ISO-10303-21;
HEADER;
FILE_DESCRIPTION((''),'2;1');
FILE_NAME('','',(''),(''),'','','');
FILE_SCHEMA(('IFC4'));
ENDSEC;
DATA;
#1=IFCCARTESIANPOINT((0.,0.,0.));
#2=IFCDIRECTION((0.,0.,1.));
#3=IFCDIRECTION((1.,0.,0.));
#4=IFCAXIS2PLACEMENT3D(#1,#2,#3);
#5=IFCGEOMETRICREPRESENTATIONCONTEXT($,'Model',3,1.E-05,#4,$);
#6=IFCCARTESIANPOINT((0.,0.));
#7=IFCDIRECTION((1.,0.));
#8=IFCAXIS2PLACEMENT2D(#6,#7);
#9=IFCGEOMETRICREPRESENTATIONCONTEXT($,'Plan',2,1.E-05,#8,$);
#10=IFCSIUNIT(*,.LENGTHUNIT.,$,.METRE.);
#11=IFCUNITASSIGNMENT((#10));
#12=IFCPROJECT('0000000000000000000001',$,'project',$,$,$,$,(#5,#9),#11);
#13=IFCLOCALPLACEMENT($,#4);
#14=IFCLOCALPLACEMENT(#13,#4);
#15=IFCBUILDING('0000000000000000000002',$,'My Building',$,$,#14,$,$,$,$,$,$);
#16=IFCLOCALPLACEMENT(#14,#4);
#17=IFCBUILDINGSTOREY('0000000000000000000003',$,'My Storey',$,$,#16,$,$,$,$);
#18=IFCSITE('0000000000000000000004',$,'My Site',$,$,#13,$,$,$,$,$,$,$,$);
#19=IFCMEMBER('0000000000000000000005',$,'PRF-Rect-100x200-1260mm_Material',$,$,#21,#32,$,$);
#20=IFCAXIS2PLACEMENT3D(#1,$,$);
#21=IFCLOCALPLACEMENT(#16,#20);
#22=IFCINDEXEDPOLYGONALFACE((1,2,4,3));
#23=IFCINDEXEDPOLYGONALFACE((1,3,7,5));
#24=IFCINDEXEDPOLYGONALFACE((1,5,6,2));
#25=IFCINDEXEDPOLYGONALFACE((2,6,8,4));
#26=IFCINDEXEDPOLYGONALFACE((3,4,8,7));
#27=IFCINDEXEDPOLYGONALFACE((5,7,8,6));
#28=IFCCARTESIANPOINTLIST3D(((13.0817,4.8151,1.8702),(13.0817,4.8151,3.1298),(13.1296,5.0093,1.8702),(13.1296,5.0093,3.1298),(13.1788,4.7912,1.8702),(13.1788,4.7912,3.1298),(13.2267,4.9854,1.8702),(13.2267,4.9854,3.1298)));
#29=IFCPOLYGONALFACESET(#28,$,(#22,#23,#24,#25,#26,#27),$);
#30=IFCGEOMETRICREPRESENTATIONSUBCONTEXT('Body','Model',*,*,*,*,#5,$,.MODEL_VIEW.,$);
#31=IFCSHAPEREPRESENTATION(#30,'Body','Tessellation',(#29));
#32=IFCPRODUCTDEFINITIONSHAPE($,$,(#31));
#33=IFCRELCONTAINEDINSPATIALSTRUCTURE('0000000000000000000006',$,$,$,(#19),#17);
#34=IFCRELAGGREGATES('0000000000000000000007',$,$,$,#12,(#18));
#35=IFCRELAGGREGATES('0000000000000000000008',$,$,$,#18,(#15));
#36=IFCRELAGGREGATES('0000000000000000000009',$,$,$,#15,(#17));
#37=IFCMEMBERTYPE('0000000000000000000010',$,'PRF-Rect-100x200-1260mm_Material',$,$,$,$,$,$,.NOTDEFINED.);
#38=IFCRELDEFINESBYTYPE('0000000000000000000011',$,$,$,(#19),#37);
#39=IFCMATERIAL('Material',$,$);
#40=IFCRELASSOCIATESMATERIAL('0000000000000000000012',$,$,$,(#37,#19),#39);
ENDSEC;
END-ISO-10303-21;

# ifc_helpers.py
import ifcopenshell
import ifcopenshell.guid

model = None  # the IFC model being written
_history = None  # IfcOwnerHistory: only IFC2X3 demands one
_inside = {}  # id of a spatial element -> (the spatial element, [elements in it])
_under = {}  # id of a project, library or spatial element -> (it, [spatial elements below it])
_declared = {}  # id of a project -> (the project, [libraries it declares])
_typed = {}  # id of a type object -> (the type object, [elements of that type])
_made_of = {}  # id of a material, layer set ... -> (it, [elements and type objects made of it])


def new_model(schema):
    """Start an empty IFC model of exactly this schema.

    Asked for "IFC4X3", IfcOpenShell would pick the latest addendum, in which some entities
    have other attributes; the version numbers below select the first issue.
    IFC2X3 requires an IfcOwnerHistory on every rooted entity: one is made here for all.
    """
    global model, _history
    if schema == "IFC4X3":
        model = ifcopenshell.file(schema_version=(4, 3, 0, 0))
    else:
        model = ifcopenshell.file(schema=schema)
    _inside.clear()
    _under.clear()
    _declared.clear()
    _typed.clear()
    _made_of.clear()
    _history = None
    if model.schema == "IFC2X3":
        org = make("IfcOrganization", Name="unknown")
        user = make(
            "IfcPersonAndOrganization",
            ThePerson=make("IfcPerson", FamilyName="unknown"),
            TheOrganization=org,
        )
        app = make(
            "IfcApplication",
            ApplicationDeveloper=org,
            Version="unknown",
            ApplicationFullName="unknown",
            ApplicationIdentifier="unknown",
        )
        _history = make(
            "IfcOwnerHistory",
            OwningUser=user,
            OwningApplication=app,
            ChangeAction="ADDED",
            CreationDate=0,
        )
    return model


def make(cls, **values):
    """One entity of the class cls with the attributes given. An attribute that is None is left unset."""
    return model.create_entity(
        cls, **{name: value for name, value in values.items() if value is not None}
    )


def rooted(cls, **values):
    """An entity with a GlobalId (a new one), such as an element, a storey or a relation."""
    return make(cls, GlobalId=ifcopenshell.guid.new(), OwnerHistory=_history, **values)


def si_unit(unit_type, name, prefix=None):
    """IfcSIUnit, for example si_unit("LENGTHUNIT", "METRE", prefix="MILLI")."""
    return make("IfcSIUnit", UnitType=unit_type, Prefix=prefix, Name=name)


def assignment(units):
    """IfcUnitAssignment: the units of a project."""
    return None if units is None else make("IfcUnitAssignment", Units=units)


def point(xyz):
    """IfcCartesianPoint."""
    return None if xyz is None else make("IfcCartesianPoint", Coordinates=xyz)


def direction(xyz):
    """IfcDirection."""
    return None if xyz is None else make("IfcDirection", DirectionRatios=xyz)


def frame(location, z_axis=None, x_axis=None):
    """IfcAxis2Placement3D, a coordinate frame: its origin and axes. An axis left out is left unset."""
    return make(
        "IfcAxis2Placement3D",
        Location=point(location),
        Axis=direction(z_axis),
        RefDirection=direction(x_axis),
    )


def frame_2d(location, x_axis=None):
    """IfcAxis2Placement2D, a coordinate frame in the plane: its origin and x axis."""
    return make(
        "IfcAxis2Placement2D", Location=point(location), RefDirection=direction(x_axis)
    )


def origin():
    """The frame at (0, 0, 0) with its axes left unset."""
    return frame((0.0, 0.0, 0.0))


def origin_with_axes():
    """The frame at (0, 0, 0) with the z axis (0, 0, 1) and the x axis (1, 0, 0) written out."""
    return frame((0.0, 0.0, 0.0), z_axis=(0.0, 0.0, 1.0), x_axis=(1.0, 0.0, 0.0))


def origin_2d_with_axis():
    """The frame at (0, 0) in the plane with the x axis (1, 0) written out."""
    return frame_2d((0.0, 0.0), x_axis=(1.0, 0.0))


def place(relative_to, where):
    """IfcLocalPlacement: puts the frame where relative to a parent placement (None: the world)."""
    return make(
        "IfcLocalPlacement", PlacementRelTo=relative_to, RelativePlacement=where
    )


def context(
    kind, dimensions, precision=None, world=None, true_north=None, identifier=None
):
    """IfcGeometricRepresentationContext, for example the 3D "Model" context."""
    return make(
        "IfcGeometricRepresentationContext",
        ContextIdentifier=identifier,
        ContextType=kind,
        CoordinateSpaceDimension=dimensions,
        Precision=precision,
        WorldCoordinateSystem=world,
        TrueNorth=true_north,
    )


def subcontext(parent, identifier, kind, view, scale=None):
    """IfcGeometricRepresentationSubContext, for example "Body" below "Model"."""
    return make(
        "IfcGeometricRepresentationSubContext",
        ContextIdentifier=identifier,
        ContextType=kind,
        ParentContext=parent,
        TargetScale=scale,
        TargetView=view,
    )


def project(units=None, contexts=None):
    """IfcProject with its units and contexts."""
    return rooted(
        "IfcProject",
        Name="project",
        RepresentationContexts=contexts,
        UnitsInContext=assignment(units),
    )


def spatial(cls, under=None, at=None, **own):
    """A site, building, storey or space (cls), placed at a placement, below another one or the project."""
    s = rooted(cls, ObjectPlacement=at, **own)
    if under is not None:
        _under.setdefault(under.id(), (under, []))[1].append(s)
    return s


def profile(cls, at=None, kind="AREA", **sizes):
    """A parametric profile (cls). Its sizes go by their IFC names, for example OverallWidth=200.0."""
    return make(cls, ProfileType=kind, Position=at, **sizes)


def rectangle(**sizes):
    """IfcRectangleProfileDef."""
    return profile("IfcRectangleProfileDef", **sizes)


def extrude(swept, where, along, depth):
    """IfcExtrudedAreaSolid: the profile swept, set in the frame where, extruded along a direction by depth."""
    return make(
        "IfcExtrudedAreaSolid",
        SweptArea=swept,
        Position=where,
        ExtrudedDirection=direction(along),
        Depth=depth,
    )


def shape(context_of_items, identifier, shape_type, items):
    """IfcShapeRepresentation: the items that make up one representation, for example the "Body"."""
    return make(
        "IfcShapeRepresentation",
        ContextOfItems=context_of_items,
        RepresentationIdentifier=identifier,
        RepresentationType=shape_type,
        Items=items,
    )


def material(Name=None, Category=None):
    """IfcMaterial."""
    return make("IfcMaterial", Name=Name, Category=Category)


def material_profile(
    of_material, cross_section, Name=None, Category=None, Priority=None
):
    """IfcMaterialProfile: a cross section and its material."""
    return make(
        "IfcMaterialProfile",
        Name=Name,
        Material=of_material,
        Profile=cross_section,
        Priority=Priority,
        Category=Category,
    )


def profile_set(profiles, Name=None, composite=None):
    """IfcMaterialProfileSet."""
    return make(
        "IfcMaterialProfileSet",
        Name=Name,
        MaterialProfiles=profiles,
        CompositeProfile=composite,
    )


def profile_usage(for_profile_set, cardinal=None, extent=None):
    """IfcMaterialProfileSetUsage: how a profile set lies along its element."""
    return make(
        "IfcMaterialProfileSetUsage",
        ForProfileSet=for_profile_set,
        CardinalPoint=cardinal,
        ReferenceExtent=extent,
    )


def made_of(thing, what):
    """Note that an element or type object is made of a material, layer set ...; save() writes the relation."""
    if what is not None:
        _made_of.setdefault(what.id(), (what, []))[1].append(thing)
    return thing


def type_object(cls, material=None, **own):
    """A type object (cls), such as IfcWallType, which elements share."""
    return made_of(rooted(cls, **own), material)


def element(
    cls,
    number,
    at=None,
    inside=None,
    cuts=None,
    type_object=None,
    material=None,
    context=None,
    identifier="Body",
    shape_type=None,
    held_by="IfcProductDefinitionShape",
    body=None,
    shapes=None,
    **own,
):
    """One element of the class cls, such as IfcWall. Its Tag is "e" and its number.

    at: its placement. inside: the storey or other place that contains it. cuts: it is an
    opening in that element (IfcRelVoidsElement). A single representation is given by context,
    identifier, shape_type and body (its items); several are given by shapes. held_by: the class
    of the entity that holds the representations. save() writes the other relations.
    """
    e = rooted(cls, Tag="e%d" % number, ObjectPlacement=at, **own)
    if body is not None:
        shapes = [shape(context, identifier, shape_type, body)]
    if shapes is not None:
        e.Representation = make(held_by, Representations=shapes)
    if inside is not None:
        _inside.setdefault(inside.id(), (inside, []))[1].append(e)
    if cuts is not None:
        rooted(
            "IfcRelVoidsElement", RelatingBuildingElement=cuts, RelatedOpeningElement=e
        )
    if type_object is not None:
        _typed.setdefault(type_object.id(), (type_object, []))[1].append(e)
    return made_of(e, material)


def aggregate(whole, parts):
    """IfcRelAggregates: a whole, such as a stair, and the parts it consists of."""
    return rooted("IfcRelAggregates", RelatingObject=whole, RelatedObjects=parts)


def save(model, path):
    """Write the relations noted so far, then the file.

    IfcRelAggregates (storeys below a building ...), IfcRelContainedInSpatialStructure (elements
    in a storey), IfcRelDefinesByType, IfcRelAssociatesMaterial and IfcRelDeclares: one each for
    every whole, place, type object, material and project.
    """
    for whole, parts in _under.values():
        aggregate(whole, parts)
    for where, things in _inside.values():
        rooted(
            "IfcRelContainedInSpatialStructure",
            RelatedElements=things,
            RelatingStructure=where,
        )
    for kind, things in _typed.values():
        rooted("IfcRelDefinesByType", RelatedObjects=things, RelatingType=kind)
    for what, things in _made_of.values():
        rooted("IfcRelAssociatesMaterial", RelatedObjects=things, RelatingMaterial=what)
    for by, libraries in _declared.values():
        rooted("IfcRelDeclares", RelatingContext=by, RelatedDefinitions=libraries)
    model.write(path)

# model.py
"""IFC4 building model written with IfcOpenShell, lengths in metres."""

from ifc_helpers import new_model, si_unit, frame, origin, origin_with_axes, origin_2d_with_axis, place, context, subcontext, project, spatial, rectangle, extrude, material, material_profile, profile_set, profile_usage, type_object, element, save


model = new_model("IFC4")

# Units and contexts
model_context = context("Model", 3, precision=1e-05, world=origin_with_axes())
plan_context = context("Plan", 2, precision=1e-05, world=origin_2d_with_axis())
body_context = subcontext(model_context, "Body", "Model", "MODEL_VIEW")
ifc_project = project(units=[si_unit("LENGTHUNIT", "METRE")], contexts=[model_context, plan_context])

# Site, building, storey
site_placement = place(None, origin_with_axes())
site = spatial("IfcSite", under=ifc_project, at=site_placement, Name="My Site")
building_placement = place(site_placement, origin_with_axes())
building = spatial("IfcBuilding", under=site, at=building_placement, Name="My Building")
storey_placement = place(building_placement, origin_with_axes())
storey = spatial("IfcBuildingStorey", under=building, at=storey_placement, Name="My Storey")

# Member
ifc_material = material(Name="Material")
ifc_material_profile_1 = material_profile(ifc_material, rectangle(XDim=0.1, YDim=0.2))
ifc_profile_set_1 = profile_set([ifc_material_profile_1], Name="PRF-Rect-100x200-1260mm_Material")
member_type_1 = type_object("IfcMemberType", Name="PRF-Rect-100x200-1260mm_Material", PredefinedType="NOTDEFINED", material=ifc_profile_set_1)
ifc_profile_usage_1 = profile_usage(ifc_profile_set_1, cardinal=5)
member_1_placement = place(storey_placement, frame((13.1542, 4.9002, 3.1298), z_axis=(0.0, 0.0, -1.0), x_axis=(-0.970857, 0.239658, 0.0)))
element("IfcMember", 1, at=member_1_placement, inside=storey, type_object=member_type_1, material=ifc_profile_usage_1, Name="PRF-Rect-100x200-1260mm_Material", context=body_context, shape_type="SweptSolid", body=[
    extrude(rectangle(XDim=0.1, YDim=0.2), origin(), (0.0, 0.0, 1.0), 1.2597),
])

save(model, "model.ifc")
